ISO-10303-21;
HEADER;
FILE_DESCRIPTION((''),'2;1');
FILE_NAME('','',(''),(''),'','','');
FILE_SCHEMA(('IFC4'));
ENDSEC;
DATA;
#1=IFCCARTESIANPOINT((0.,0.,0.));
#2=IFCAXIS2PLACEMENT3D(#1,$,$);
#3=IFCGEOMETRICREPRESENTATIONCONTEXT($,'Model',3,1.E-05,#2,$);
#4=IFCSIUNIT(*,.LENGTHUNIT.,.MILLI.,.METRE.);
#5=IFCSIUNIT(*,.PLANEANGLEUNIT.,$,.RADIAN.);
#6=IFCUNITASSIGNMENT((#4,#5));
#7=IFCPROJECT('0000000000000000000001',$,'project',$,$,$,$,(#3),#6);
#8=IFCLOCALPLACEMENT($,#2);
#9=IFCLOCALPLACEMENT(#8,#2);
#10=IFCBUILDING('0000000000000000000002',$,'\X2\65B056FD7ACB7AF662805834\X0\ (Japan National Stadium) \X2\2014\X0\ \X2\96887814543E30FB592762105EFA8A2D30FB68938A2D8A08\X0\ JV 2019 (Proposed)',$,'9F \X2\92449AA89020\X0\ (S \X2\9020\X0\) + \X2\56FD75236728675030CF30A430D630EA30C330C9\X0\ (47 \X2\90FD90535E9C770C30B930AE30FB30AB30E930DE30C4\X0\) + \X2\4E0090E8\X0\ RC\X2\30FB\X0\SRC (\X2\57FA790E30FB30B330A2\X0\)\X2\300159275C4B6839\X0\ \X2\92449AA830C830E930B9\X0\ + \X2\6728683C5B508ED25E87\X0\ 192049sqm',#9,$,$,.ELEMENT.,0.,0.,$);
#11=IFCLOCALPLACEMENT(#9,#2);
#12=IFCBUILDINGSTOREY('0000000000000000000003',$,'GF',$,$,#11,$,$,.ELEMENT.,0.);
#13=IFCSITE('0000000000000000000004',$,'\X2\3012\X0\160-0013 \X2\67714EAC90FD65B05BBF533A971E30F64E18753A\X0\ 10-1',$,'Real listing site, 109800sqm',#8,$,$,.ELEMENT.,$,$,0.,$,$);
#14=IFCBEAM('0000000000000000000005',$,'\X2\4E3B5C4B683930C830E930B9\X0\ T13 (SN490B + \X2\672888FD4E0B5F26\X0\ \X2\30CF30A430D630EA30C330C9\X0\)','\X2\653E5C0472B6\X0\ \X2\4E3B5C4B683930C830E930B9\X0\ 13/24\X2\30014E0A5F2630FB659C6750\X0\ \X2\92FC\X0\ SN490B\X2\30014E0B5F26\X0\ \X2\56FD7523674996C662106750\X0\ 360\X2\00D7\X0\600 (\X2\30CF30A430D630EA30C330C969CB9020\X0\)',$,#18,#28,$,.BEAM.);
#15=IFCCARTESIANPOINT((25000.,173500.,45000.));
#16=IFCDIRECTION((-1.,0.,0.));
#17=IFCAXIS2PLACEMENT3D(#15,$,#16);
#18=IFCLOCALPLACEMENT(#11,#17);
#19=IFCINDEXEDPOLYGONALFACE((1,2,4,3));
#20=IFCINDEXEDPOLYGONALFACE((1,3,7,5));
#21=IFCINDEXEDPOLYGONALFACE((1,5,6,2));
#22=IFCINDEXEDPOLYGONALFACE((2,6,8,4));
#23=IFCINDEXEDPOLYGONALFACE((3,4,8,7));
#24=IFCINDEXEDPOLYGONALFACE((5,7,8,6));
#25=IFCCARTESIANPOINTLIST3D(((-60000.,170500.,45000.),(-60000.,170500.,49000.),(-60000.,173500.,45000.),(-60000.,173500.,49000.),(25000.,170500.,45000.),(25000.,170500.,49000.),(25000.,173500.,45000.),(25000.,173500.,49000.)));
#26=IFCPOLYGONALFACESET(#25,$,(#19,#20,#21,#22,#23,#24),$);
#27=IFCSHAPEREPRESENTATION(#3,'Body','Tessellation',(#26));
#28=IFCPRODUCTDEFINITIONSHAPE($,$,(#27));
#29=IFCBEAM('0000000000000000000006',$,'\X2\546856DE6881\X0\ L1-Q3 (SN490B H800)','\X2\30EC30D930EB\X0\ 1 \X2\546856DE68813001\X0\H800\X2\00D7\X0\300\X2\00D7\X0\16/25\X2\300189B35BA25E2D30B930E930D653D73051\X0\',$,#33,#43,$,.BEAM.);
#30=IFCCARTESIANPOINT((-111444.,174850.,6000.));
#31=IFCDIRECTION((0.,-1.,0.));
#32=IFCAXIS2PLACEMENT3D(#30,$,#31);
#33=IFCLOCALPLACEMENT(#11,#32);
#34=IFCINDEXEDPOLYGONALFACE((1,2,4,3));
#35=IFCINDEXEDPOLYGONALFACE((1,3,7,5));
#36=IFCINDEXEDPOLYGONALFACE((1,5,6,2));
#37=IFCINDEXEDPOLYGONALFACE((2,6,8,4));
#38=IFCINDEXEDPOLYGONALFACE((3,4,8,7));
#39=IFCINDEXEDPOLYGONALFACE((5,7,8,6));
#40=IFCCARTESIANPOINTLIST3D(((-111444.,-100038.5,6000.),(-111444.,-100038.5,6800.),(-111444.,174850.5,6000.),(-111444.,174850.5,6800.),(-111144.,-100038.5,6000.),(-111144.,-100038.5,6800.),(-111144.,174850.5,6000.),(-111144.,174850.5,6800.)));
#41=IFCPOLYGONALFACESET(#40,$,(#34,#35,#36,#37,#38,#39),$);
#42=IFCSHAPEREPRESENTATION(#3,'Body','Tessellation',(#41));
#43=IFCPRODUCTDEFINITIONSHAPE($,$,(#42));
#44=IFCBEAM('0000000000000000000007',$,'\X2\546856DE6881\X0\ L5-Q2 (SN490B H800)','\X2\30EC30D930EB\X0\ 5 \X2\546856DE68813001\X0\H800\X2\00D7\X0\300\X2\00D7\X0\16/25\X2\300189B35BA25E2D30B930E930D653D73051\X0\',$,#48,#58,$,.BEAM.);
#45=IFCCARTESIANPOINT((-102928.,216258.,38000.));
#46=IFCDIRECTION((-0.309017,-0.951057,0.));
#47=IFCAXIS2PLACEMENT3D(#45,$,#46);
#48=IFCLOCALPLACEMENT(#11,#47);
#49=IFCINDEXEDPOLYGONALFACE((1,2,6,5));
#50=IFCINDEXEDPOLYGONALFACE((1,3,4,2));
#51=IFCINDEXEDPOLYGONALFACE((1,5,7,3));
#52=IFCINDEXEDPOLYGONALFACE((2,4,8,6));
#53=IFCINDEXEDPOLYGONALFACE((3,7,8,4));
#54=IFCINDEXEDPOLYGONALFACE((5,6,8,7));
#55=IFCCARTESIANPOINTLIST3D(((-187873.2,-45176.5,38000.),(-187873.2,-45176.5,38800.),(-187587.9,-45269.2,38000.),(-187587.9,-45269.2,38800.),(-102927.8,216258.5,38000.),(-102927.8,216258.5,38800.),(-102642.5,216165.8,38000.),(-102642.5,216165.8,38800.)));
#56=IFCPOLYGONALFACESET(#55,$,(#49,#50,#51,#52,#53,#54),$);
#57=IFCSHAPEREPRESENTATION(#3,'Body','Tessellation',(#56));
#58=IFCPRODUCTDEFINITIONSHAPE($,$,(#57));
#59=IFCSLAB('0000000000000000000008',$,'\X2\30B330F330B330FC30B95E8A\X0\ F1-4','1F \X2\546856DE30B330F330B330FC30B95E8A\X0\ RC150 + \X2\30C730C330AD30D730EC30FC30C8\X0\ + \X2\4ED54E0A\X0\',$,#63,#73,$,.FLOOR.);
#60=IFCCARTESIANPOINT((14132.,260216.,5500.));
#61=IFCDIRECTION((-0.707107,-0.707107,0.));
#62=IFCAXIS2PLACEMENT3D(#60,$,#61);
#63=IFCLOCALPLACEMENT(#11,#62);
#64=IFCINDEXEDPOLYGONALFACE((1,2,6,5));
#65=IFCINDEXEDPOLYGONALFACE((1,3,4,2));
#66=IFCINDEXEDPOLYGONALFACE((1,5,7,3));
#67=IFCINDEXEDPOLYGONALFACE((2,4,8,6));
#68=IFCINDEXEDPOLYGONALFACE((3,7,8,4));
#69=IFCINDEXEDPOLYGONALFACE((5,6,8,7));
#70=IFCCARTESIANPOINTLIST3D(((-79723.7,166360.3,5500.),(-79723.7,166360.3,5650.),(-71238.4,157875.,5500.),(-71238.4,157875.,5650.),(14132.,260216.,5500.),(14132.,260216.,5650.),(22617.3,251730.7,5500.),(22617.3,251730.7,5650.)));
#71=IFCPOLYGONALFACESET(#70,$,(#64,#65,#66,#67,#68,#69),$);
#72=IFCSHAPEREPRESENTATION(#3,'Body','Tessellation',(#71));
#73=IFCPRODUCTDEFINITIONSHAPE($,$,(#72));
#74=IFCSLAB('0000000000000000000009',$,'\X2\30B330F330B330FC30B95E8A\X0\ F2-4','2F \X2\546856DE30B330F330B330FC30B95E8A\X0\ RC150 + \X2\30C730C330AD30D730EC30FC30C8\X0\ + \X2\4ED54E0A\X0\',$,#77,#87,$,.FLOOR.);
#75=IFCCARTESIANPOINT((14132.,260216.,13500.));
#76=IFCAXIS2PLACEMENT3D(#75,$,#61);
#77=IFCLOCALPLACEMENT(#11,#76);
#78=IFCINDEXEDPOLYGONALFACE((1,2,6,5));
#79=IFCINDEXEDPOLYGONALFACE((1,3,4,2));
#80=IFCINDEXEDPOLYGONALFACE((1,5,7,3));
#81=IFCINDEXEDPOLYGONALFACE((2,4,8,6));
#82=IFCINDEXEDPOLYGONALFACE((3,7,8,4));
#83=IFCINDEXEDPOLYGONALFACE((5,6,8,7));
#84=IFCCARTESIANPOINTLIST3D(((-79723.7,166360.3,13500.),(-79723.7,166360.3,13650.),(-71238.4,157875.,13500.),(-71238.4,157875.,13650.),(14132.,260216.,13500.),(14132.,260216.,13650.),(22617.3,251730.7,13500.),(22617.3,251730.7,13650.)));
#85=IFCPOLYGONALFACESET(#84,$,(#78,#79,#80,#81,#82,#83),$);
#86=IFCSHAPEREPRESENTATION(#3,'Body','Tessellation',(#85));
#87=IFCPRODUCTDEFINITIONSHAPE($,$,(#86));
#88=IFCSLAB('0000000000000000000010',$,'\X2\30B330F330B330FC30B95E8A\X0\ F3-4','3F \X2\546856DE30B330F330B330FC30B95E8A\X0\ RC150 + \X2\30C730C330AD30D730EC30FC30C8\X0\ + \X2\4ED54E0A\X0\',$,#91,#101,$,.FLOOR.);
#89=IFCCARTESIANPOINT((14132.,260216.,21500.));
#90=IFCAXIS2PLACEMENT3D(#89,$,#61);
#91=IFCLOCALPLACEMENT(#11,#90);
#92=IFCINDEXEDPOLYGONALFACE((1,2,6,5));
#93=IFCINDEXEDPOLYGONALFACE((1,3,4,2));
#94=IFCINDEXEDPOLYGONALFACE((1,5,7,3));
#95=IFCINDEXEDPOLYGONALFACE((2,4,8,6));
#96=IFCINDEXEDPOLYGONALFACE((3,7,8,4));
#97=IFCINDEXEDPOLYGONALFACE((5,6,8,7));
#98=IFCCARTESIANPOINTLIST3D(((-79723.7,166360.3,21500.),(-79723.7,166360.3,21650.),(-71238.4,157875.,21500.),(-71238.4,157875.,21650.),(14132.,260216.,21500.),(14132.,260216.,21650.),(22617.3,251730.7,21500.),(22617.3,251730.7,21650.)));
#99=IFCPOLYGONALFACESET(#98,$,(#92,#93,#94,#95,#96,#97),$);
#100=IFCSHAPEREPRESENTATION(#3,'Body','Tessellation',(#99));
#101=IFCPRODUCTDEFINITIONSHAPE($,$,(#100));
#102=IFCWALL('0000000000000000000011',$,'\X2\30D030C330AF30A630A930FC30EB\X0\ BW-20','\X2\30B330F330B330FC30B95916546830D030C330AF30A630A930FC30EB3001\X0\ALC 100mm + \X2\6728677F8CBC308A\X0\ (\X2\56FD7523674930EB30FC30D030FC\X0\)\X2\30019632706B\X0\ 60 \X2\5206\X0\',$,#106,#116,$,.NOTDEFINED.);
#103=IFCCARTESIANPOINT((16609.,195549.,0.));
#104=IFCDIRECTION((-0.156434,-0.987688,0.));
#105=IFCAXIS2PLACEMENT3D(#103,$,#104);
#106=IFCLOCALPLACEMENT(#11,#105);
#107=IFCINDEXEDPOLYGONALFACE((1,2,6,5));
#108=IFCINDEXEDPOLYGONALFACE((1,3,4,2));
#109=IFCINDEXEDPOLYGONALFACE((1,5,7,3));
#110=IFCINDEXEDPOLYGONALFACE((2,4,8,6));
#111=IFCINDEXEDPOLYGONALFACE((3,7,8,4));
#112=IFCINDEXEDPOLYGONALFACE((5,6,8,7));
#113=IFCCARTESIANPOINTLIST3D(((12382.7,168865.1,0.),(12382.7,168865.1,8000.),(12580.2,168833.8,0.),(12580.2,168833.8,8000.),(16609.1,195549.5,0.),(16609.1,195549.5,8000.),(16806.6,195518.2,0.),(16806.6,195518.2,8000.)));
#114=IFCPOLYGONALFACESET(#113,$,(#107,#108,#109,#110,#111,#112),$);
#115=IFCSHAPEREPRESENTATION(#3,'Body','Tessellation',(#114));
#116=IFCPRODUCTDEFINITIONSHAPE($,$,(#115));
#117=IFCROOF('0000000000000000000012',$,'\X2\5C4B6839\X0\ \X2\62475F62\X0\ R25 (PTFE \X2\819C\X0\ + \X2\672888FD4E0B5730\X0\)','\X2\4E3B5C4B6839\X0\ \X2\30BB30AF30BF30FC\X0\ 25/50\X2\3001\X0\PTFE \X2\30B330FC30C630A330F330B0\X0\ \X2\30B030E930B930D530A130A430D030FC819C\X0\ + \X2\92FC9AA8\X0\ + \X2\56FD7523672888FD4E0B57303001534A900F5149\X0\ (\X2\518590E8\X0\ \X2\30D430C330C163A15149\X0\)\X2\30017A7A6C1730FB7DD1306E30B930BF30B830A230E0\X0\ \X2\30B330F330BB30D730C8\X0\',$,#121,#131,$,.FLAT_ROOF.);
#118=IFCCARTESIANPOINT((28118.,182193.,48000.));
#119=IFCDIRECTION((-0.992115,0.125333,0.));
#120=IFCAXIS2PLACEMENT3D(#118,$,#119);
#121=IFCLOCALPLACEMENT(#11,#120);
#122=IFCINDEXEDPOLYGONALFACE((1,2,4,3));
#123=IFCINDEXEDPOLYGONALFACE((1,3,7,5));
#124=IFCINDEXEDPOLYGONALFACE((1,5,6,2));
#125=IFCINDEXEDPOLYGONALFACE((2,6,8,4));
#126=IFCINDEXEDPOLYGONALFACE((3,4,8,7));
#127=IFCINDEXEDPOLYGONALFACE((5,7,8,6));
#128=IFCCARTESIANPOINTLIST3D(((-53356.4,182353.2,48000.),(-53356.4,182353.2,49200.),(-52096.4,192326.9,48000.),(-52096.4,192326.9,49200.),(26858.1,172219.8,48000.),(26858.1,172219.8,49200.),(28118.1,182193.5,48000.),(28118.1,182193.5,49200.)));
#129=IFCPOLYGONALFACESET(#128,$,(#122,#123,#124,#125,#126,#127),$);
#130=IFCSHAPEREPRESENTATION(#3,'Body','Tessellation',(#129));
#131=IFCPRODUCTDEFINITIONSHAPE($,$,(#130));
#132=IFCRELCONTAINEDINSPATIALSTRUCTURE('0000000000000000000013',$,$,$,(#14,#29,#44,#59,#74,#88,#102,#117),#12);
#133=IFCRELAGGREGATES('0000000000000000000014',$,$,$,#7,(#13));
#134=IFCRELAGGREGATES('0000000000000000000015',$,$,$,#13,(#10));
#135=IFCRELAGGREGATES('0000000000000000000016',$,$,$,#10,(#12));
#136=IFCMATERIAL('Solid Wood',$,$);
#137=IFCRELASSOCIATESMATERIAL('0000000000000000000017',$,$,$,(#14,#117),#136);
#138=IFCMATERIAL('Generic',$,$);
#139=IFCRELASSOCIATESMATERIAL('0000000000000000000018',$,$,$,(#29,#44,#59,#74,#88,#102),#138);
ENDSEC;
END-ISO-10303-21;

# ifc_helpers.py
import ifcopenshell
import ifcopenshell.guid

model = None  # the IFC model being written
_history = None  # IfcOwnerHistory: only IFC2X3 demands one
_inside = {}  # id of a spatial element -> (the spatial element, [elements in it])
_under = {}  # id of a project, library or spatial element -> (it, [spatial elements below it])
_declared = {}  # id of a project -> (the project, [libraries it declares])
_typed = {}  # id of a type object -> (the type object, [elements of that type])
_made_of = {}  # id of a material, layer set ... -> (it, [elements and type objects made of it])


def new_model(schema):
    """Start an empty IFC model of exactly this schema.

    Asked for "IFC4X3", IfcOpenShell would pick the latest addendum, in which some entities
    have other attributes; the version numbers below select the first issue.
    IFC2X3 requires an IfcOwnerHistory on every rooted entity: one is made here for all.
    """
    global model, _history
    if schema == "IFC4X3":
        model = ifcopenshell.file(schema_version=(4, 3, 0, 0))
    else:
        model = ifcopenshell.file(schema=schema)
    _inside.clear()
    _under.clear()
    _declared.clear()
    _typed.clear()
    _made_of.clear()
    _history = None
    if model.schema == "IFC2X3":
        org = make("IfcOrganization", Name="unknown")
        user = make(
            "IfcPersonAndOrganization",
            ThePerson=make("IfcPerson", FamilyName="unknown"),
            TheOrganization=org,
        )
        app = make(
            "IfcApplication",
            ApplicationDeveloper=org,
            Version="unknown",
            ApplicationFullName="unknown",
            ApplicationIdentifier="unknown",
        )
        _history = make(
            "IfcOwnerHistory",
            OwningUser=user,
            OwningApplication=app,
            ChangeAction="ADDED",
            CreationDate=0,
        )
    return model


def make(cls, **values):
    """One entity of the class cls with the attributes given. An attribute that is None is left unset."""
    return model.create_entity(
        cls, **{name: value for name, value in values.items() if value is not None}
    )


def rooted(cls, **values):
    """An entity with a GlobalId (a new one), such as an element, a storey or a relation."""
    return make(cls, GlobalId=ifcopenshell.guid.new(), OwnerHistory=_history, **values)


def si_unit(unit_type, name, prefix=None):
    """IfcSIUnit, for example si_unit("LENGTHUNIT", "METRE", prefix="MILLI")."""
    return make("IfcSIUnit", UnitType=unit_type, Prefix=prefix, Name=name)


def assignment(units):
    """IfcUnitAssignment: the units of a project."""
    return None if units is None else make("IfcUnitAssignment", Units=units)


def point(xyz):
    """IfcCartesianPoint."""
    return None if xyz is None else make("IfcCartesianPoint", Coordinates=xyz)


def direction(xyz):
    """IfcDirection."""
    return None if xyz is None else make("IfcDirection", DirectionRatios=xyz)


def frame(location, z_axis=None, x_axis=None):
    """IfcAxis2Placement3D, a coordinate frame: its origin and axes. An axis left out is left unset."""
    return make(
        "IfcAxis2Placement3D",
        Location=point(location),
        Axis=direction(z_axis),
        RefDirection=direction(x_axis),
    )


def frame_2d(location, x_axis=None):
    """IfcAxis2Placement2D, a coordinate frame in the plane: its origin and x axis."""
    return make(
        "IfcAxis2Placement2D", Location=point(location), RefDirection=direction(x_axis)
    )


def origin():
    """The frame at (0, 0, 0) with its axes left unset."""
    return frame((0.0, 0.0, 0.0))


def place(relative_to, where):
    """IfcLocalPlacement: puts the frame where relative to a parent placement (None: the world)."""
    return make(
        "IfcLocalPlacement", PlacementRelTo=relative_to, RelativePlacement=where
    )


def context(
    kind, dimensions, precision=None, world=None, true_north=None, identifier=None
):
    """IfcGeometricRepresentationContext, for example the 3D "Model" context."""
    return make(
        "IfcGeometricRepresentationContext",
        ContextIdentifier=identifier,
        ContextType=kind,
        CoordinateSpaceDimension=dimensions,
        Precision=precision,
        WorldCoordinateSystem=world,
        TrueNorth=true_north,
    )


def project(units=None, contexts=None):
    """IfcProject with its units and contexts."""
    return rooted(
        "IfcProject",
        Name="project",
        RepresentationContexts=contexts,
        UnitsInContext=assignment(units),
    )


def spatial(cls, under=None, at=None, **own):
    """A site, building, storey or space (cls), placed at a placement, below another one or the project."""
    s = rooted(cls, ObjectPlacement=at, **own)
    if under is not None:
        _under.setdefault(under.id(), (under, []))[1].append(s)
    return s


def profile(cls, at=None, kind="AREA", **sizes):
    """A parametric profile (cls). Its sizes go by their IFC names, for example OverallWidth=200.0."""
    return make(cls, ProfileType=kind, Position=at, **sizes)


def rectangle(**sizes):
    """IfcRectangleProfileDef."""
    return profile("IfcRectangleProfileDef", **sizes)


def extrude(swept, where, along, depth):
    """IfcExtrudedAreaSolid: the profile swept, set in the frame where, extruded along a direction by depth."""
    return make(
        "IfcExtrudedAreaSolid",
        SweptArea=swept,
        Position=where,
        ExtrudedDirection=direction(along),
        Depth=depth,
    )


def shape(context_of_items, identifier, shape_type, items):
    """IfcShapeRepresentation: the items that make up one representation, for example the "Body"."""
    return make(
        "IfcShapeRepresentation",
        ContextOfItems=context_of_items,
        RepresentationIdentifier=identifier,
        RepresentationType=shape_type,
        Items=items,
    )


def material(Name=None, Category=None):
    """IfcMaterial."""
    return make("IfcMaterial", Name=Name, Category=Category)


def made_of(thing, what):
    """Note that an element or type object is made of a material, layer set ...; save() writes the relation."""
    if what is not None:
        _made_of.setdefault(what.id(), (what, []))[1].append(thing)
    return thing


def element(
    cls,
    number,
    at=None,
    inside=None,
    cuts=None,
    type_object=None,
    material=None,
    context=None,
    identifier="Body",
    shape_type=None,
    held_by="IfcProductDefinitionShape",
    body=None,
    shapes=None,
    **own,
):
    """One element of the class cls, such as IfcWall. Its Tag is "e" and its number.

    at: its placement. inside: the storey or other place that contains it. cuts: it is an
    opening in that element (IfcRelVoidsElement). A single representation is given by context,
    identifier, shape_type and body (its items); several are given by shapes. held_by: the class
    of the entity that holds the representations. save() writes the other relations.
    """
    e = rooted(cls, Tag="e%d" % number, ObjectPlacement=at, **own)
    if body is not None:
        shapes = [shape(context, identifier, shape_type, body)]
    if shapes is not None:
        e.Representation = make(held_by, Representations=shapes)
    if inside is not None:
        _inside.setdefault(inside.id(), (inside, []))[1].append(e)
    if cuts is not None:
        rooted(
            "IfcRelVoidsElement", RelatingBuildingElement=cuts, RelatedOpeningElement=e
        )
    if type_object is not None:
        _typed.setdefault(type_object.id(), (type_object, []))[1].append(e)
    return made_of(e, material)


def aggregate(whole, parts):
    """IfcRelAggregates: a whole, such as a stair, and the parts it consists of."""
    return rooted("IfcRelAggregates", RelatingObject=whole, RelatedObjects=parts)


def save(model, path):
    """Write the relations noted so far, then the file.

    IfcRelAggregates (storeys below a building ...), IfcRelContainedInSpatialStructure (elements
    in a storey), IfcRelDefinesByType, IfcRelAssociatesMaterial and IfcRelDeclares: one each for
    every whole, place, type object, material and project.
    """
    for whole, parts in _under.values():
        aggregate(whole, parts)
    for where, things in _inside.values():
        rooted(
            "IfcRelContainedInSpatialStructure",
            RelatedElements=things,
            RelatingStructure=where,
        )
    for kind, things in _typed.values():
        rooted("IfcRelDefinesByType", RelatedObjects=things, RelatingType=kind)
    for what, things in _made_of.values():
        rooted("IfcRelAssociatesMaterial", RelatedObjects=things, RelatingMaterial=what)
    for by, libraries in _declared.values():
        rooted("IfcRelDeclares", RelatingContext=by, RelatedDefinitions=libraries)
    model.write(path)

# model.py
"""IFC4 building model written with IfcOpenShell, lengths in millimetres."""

from ifc_helpers import new_model, si_unit, frame, frame_2d, origin, place, context, project, spatial, rectangle, extrude, material, element, save


model = new_model("IFC4")

# Units and contexts
model_context = context("Model", 3, precision=1e-05, world=origin())
ifc_project = project(units=[si_unit("LENGTHUNIT", "METRE", prefix="MILLI"), si_unit("PLANEANGLEUNIT", "RADIAN")], contexts=[model_context])

# Site, building, storey
site_placement = place(None, origin())
site = spatial("IfcSite", under=ifc_project, at=site_placement, Name="〒160-0013 東京都新宿区霞ヶ丘町 10-1", ObjectType="Real listing site, 109800sqm", CompositionType="ELEMENT", RefElevation=0.0)
building_placement = place(site_placement, origin())
building = spatial("IfcBuilding", under=site, at=building_placement, Name="新国立競技場 (Japan National Stadium) — 隈研吾・大成建設・梓設計 JV 2019 (Proposed)", ObjectType="9F 鉄骨造 (S 造) + 国産木材ハイブリッド (47 都道府県スギ・カラマツ) + 一部 RC・SRC (基礎・コア)、大屋根 鉄骨トラス + 木格子軒庇 192049sqm", CompositionType="ELEMENT", ElevationOfRefHeight=0.0, ElevationOfTerrain=0.0)
storey_placement = place(building_placement, origin())
storey = spatial("IfcBuildingStorey", under=building, at=storey_placement, Name="GF", CompositionType="ELEMENT", Elevation=0.0)

# Shared definitions
ifc_material_1 = material(Name="Generic")

# Beams
ifc_material_2 = material(Name="Solid Wood")
beam_1_placement = place(storey_placement, frame((25000.0, 173500.0, 45000.0), x_axis=(-1.0, 0.0, 0.0)))
element("IfcBeam", 1, at=beam_1_placement, inside=storey, material=ifc_material_2, Name="主屋根トラス T13 (SN490B + 木製下弦 ハイブリッド)", Description="放射状 主屋根トラス 13/24、上弦・斜材 鋼 SN490B、下弦 国産杉集成材 360×600 (ハイブリッド構造)", PredefinedType="BEAM", context=model_context, shape_type="SweptSolid", body=[
    extrude(rectangle(XDim=85000.0, YDim=3000.0, at=frame_2d((42500.0, 1500.0))), frame((25000.0, 173500.0, 45000.0), x_axis=(-1.0, 0.0, 0.0)), (0.0, 0.0, 1.0), 4000.0),
])
beam_2_placement = place(storey_placement, frame((-111444.0, 174850.0, 6000.0), x_axis=(0.0, -1.0, 0.0)))
element("IfcBeam", 2, at=beam_2_placement, inside=storey, material=ifc_material_1, Name="周回梁 L1-Q3 (SN490B H800)", Description="レベル 1 周回梁、H800×300×16/25、観客席スラブ受け", PredefinedType="BEAM", context=model_context, shape_type="SweptSolid", body=[
    extrude(rectangle(XDim=274889.0, YDim=300.0, at=frame_2d((137444.0, 150.0))), frame((-111444.0, 174850.0, 6000.0), x_axis=(0.0, -1.0, 0.0)), (0.0, 0.0, 1.0), 800.0),
])
beam_3_placement = place(storey_placement, frame((-102928.0, 216258.0, 38000.0), x_axis=(-0.309017, -0.951057, 0.0)))
element("IfcBeam", 3, at=beam_3_placement, inside=storey, material=ifc_material_1, Name="周回梁 L5-Q2 (SN490B H800)", Description="レベル 5 周回梁、H800×300×16/25、観客席スラブ受け", PredefinedType="BEAM", context=model_context, shape_type="SweptSolid", body=[
    extrude(rectangle(XDim=274889.0, YDim=300.0, at=frame_2d((137444.0, 150.0))), frame((-102928.0, 216258.0, 38000.0), x_axis=(-0.309017, -0.951057, 0.0)), (0.0, 0.0, 1.0), 800.0),
])

# Slabs
slab_1_placement = place(storey_placement, frame((14132.0, 260216.0, 5500.0), x_axis=(-0.707107, -0.707107, 0.0)))
element("IfcSlab", 4, at=slab_1_placement, inside=storey, material=ifc_material_1, Name="コンコース床 F1-4", Description="1F 周回コンコース床 RC150 + デッキプレート + 仕上", PredefinedType="FLOOR", context=model_context, shape_type="SweptSolid", body=[
    extrude(rectangle(XDim=132732.0, YDim=12000.0, at=frame_2d((66366.0, 6000.0))), frame((14132.0, 260216.0, 5500.0), x_axis=(-0.707107, -0.707107, 0.0)), (0.0, 0.0, 1.0), 150.0),
])
slab_2_placement = place(storey_placement, frame((14132.0, 260216.0, 13500.0), x_axis=(-0.707107, -0.707107, 0.0)))
element("IfcSlab", 5, at=slab_2_placement, inside=storey, material=ifc_material_1, Name="コンコース床 F2-4", Description="2F 周回コンコース床 RC150 + デッキプレート + 仕上", PredefinedType="FLOOR", context=model_context, shape_type="SweptSolid", body=[
    extrude(rectangle(XDim=132732.0, YDim=12000.0, at=frame_2d((66366.0, 6000.0))), frame((14132.0, 260216.0, 13500.0), x_axis=(-0.707107, -0.707107, 0.0)), (0.0, 0.0, 1.0), 150.0),
])
slab_3_placement = place(storey_placement, frame((14132.0, 260216.0, 21500.0), x_axis=(-0.707107, -0.707107, 0.0)))
element("IfcSlab", 6, at=slab_3_placement, inside=storey, material=ifc_material_1, Name="コンコース床 F3-4", Description="3F 周回コンコース床 RC150 + デッキプレート + 仕上", PredefinedType="FLOOR", context=model_context, shape_type="SweptSolid", body=[
    extrude(rectangle(XDim=132732.0, YDim=12000.0, at=frame_2d((66366.0, 6000.0))), frame((14132.0, 260216.0, 21500.0), x_axis=(-0.707107, -0.707107, 0.0)), (0.0, 0.0, 1.0), 150.0),
])

# Wall
wall_1_placement = place(storey_placement, frame((16609.0, 195549.0, 0.0), x_axis=(-0.156434, -0.987688, 0.0)))
element("IfcWall", 7, at=wall_1_placement, inside=storey, material=ifc_material_1, Name="バックウォール BW-20", Description="コンコース外周バックウォール、ALC 100mm + 木板貼り (国産杉ルーバー)、防火 60 分", PredefinedType="NOTDEFINED", context=model_context, shape_type="SweptSolid", body=[
    extrude(rectangle(XDim=27017.0, YDim=200.0, at=frame_2d((13508.0, 100.0))), frame((16609.0, 195549.0, 0.0), x_axis=(-0.156434, -0.987688, 0.0)), (0.0, 0.0, 1.0), 8000.0),
])

# Roof
roof_1_placement = place(storey_placement, frame((28118.0, 182193.0, 48000.0), x_axis=(-0.992115, 0.125333, 0.0)))
element("IfcRoof", 8, at=roof_1_placement, inside=storey, material=ifc_material_2, Name="屋根 扇形 R25 (PTFE 膜 + 木製下地)", Description="主屋根 セクター 25/50、PTFE コーティング グラスファイバー膜 + 鋼骨 + 国産木製下地、半透光 (内部 ピッチ採光)、空気・緑のスタジアム コンセプト", PredefinedType="FLAT_ROOF", context=model_context, shape_type="SweptSolid", body=[
    extrude(rectangle(XDim=80852.0, YDim=10053.0, at=frame_2d((40426.0, 5026.0))), frame((28118.0, 182193.0, 48000.0), x_axis=(-0.992115, 0.125333, 0.0)), (0.0, 0.0, 1.0), 1200.0),
])

save(model, "model.ifc")
